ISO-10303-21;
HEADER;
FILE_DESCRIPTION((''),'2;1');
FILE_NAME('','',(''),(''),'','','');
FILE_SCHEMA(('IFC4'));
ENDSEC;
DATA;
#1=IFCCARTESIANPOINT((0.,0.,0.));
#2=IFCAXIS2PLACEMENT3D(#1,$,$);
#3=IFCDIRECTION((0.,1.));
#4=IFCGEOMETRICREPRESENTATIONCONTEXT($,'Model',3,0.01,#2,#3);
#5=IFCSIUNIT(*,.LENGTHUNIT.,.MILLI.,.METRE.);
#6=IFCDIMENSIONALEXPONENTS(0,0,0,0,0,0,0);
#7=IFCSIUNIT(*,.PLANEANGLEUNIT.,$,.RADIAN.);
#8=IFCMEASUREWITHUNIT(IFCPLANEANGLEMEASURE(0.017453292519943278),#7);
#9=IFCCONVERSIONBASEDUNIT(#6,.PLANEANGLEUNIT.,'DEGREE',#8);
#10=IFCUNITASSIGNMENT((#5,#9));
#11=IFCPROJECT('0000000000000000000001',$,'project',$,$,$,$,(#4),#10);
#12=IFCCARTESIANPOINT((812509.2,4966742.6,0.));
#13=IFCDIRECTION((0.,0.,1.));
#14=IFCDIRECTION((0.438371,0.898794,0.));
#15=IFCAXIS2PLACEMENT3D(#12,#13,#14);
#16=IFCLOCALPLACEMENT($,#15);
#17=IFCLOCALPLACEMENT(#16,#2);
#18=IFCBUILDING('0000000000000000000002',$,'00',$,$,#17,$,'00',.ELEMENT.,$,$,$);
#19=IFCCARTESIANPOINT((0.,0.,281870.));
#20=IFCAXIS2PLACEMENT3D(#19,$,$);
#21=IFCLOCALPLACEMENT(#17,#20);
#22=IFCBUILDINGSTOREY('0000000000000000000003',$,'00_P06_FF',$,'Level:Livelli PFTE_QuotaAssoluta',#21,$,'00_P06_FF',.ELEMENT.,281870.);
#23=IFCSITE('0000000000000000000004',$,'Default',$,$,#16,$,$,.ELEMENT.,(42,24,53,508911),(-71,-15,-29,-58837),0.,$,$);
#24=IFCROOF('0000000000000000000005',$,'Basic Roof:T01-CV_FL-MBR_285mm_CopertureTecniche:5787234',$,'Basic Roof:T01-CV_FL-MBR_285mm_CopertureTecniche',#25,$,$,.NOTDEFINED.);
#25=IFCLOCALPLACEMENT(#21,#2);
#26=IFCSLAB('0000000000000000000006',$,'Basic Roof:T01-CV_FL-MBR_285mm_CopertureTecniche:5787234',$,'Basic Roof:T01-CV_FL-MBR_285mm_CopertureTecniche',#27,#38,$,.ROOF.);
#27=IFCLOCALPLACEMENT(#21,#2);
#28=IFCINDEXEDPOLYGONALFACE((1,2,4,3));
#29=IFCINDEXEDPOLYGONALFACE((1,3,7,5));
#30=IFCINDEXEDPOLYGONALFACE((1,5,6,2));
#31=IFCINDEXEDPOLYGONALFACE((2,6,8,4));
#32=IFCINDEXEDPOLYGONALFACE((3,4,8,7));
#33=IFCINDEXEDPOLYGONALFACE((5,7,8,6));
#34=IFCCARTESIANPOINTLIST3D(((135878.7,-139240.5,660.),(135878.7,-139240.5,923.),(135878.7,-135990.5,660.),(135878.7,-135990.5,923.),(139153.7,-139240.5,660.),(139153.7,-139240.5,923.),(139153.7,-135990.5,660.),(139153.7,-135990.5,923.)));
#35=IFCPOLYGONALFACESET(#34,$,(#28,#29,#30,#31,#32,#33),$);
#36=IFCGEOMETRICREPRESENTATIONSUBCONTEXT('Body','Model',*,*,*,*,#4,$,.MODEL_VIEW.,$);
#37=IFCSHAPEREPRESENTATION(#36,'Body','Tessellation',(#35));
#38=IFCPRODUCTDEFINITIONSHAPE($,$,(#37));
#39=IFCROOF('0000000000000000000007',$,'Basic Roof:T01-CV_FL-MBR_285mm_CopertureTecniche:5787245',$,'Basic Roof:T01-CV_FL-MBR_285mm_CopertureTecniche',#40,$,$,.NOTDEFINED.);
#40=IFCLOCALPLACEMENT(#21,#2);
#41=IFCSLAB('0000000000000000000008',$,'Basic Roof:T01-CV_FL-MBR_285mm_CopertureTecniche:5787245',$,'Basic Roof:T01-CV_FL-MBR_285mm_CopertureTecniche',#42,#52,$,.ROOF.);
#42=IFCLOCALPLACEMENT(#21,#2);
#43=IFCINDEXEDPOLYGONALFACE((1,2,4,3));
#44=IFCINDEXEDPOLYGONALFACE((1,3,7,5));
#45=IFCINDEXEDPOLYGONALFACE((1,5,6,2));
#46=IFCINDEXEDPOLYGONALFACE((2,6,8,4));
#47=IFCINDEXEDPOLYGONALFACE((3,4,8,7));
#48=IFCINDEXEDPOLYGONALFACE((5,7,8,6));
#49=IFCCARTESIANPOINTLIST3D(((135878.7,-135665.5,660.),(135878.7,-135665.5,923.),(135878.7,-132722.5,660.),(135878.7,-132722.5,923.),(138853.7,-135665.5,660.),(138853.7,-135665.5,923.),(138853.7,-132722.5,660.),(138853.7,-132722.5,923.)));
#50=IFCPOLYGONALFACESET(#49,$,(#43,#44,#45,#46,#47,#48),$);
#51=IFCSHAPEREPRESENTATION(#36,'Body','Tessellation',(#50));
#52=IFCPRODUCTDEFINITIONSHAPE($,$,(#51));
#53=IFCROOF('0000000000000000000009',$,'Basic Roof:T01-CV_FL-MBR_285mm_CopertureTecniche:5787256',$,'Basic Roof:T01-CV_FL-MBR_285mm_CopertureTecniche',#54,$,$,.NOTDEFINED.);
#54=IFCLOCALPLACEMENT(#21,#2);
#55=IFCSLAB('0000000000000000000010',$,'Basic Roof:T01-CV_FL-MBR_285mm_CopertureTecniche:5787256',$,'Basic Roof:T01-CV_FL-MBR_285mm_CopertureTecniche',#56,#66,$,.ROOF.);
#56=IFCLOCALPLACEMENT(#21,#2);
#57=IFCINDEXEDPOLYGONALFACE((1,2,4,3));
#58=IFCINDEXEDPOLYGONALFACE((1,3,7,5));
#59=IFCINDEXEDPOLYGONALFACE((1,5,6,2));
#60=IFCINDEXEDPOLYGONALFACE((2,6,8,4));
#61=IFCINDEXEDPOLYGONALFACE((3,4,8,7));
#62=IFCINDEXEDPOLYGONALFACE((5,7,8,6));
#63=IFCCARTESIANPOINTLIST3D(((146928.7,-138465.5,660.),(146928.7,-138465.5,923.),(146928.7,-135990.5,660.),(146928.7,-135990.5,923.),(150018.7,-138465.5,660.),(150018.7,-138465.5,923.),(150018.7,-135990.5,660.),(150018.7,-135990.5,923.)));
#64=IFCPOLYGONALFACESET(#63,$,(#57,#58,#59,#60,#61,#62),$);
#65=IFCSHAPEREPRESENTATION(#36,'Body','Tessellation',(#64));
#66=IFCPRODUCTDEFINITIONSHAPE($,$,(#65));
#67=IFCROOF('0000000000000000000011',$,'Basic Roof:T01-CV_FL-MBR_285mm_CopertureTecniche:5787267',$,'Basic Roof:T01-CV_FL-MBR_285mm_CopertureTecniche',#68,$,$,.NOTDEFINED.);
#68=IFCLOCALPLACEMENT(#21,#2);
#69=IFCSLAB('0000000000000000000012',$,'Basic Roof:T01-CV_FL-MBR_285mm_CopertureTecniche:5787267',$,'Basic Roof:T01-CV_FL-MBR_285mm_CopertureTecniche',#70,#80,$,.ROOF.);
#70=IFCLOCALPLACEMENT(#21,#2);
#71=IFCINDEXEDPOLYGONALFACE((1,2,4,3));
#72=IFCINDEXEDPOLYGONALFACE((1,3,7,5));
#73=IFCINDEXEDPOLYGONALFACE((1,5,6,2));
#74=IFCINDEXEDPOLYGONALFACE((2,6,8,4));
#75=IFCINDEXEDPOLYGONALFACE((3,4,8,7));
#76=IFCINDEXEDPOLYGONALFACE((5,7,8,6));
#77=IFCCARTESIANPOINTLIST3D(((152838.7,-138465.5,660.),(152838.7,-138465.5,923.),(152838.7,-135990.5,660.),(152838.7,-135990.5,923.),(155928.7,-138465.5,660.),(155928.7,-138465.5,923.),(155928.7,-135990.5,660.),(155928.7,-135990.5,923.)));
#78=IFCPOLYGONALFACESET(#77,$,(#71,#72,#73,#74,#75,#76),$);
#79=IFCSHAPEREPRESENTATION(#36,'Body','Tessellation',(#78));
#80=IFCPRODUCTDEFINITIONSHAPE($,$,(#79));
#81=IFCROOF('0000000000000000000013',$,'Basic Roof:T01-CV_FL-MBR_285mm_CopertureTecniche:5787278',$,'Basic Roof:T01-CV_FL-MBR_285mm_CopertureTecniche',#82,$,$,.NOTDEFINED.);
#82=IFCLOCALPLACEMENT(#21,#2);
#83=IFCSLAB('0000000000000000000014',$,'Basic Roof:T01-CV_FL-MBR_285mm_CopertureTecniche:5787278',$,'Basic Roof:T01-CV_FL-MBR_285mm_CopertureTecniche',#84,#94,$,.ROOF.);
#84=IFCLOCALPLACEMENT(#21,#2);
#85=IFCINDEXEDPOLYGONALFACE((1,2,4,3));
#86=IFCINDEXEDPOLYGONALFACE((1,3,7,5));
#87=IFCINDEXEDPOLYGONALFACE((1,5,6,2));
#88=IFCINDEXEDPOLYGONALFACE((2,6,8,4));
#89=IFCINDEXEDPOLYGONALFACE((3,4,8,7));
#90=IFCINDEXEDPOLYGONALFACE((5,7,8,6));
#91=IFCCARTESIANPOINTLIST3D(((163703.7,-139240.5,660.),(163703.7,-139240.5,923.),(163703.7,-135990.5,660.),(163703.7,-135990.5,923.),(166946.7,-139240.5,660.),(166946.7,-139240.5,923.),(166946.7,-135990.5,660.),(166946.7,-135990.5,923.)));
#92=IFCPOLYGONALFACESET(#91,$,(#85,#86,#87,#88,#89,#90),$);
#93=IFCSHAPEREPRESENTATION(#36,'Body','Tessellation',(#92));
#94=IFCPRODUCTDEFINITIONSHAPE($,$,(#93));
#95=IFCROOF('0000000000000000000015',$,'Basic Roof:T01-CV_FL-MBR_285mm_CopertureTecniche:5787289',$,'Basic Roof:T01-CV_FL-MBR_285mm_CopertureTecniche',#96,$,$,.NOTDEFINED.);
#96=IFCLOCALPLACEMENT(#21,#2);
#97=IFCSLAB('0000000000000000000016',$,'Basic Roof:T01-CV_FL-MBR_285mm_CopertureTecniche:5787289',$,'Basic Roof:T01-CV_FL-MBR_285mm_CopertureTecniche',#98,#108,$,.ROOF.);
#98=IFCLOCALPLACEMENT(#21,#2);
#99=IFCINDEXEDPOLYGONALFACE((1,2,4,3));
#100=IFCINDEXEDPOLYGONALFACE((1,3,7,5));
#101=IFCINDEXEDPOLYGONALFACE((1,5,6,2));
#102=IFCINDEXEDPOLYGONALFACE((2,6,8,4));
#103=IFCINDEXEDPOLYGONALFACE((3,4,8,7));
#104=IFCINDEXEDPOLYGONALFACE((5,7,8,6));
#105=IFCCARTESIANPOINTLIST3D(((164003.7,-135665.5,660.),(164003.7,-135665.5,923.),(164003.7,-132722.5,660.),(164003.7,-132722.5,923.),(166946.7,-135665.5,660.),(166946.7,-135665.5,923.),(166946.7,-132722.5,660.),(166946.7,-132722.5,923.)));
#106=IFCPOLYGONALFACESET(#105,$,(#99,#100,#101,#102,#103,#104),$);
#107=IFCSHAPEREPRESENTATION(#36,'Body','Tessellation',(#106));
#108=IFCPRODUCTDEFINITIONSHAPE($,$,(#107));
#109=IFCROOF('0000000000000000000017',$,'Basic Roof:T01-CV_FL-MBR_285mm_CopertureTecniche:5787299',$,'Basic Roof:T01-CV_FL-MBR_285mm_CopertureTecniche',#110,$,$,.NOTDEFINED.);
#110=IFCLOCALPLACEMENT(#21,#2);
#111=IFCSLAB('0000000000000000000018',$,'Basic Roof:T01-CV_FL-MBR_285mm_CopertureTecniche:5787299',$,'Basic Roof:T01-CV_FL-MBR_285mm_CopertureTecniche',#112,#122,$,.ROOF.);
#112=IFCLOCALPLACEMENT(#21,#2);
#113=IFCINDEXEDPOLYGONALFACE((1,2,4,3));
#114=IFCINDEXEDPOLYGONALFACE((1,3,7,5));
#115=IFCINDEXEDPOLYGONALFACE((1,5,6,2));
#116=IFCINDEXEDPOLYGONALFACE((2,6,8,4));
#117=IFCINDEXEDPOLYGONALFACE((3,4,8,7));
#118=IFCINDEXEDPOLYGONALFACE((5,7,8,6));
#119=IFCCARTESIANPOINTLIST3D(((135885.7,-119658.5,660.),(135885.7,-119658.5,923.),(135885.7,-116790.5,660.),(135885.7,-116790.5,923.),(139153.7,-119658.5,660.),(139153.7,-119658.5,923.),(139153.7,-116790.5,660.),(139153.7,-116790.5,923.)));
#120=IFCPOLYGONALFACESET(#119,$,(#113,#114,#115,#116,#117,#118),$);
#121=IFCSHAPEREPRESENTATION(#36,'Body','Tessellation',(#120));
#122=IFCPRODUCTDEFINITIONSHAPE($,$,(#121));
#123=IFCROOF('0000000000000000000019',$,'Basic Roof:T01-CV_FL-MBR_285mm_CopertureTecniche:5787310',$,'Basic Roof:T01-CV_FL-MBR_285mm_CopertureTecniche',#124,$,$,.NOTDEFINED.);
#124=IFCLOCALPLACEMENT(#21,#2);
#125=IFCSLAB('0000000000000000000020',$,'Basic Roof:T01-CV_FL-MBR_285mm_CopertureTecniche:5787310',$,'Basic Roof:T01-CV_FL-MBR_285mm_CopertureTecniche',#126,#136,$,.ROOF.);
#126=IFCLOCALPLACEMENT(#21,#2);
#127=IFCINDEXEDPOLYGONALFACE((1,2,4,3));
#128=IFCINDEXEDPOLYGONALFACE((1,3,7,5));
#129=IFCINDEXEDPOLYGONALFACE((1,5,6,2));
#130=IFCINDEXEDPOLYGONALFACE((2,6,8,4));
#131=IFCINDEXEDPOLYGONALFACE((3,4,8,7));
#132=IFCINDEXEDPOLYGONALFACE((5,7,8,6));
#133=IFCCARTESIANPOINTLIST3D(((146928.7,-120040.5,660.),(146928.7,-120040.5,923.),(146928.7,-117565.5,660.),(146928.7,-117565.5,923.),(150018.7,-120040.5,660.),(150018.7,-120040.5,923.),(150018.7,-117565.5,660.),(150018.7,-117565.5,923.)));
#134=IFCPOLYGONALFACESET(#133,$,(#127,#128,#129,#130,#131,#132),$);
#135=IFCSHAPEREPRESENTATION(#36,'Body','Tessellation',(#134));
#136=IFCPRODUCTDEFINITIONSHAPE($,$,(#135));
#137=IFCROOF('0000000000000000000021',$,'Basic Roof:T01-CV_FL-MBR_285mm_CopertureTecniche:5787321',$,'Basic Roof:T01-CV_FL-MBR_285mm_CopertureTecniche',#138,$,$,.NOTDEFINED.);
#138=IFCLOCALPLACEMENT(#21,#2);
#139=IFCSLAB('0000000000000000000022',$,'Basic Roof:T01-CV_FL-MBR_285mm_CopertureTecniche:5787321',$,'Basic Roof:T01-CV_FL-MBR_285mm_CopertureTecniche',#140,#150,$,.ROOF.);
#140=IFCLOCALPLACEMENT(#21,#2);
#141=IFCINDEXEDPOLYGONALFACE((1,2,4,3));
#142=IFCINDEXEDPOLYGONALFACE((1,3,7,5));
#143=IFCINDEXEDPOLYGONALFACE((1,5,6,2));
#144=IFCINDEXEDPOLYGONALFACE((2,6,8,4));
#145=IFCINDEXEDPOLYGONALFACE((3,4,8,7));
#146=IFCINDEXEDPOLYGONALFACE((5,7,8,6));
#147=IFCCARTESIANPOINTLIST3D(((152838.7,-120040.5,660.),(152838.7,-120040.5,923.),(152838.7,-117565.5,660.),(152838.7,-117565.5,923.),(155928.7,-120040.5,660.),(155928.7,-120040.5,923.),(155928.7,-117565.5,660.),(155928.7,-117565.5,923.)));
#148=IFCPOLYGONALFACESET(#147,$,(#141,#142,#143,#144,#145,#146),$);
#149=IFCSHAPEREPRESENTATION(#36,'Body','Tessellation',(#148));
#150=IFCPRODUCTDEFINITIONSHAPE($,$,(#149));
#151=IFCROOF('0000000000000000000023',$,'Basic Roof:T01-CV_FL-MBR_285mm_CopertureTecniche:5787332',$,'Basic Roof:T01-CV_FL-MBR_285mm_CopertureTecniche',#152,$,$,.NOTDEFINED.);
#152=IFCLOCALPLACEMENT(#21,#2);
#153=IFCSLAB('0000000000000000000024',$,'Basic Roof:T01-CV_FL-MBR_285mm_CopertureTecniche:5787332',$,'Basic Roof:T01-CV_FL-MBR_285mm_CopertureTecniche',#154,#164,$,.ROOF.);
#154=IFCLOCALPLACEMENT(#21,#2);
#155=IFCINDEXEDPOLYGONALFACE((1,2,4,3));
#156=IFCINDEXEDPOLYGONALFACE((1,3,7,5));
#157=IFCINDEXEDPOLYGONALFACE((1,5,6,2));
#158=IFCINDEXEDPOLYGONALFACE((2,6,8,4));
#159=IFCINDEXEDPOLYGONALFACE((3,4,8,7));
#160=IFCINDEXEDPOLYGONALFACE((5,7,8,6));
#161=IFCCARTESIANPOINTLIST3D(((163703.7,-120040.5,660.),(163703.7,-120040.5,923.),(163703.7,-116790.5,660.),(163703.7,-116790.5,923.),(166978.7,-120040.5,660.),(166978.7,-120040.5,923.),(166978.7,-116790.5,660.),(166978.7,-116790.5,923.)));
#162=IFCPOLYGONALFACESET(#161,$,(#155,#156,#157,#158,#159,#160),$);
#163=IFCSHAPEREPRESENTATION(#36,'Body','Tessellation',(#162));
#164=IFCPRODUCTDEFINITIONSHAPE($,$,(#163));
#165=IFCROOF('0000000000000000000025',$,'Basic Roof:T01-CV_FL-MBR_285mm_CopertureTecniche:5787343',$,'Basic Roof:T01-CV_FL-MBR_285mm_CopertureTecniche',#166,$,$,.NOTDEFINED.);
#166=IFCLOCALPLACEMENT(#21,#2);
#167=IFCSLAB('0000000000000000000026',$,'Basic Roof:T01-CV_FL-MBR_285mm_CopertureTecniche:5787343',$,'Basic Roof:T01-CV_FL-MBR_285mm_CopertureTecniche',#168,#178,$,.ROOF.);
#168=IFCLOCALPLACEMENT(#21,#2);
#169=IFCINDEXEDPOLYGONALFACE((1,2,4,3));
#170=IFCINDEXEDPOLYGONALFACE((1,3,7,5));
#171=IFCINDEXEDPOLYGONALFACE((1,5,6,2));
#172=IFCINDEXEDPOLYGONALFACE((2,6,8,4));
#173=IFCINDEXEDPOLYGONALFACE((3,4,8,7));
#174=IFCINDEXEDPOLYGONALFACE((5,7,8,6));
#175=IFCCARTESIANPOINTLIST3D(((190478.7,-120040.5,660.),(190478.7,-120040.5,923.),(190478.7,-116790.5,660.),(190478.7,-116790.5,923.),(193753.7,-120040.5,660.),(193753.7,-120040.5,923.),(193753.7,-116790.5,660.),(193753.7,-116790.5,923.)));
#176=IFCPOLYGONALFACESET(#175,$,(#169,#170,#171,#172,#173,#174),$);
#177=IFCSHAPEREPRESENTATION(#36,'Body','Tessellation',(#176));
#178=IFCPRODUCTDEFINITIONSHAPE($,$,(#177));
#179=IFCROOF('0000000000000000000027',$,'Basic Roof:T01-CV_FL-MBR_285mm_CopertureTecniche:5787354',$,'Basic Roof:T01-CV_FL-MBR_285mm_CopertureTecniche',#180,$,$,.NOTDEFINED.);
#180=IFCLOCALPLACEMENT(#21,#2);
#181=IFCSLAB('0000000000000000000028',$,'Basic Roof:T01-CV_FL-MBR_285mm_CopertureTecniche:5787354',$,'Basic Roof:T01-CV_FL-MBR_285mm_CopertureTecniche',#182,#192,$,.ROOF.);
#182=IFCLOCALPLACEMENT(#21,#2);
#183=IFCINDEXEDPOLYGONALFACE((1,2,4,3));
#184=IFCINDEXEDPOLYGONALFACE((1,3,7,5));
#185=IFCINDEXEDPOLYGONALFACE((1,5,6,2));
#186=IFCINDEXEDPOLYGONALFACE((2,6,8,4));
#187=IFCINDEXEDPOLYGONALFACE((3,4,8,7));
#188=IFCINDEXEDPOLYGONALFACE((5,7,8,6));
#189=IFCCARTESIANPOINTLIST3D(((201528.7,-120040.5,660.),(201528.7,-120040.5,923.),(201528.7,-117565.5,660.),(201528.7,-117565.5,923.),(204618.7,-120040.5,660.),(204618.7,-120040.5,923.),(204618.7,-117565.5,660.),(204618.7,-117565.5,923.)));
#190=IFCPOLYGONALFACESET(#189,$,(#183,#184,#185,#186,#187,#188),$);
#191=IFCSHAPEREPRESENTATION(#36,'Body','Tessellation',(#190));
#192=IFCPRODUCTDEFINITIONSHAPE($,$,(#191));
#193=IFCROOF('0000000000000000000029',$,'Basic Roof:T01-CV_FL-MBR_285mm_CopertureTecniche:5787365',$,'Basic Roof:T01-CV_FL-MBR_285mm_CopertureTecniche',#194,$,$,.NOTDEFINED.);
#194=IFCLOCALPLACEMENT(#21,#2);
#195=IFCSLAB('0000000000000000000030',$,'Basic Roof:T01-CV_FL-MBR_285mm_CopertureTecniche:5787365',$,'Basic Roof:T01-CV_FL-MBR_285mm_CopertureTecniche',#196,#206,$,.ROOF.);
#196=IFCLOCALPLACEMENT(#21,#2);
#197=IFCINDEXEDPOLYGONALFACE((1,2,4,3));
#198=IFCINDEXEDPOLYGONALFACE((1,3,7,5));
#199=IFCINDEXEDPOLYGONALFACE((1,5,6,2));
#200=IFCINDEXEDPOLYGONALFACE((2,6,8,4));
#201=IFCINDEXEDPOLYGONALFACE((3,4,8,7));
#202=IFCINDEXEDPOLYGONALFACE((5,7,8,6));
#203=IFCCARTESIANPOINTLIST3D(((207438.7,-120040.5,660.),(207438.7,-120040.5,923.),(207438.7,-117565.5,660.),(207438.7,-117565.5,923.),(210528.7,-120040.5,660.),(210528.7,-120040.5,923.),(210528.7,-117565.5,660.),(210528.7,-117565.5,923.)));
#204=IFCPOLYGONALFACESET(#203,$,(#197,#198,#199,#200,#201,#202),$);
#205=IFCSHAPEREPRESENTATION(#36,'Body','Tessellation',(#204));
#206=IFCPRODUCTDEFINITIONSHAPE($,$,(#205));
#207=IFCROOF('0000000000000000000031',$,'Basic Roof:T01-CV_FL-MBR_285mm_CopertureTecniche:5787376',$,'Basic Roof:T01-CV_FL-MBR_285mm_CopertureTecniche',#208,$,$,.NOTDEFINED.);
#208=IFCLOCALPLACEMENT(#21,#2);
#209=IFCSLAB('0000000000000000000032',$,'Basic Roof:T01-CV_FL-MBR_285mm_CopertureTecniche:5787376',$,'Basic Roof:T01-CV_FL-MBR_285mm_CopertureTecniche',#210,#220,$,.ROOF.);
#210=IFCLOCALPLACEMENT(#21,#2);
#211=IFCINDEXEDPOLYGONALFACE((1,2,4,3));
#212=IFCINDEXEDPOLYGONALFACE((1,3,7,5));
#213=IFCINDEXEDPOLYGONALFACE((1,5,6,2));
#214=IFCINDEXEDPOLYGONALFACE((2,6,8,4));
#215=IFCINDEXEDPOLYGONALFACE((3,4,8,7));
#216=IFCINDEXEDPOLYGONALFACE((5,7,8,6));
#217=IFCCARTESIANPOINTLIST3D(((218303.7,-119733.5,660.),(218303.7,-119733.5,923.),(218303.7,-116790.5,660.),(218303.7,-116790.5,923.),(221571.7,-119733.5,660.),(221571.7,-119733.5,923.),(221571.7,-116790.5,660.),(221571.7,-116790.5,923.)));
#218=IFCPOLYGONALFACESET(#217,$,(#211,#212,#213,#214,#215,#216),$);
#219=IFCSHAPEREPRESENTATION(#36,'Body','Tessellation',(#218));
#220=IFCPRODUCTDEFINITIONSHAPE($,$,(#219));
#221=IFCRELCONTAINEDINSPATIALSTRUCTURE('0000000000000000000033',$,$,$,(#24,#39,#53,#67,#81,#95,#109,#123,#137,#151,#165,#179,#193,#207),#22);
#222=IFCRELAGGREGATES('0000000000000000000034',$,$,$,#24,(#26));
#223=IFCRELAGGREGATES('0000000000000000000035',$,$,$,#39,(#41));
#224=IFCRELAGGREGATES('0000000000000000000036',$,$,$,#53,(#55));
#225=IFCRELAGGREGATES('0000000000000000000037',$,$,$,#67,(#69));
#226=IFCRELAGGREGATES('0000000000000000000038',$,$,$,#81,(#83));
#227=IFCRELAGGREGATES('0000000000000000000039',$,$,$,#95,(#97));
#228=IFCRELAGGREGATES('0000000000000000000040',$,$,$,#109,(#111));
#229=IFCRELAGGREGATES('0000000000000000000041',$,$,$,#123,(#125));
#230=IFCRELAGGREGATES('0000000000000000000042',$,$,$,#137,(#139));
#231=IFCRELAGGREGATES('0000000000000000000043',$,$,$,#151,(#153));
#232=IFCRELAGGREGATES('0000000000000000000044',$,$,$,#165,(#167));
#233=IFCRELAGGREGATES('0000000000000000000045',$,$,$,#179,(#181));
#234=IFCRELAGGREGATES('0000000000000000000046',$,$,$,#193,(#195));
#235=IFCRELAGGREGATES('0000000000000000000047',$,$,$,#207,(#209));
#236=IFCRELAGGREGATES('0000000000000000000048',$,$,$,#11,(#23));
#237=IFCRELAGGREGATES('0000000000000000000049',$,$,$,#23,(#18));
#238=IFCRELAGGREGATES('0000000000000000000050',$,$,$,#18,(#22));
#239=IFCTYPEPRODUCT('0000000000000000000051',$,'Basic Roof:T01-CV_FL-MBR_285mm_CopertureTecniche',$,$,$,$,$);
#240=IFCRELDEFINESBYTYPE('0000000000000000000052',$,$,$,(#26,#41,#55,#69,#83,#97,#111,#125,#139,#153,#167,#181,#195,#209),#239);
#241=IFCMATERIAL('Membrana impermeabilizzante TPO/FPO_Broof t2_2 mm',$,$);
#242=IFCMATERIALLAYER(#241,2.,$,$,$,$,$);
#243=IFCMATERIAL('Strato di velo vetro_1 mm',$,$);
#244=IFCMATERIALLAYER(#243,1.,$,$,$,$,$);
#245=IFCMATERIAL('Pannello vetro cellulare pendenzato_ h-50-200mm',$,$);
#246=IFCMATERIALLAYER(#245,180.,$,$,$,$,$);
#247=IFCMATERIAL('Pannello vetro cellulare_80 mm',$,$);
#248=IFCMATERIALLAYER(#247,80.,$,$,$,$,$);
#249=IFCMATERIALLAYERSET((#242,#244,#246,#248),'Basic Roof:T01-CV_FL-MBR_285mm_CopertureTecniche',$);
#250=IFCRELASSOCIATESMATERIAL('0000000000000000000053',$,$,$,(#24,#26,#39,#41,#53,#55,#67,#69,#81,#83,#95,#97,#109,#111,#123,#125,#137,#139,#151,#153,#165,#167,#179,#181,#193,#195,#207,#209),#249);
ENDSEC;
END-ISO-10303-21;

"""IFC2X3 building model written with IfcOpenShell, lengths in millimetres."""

from ifc_helpers import new_model, entity, si_unit, converted_unit, direction, frame, frame_2d, origin, place, context, subcontext, project, spatial, rectangle, extrude, material, layer, layer_set, type_object, element, aggregate, save


model = new_model("IFC2X3")

# Units and contexts
model_context = context("Model", 3, precision=0.01, world=origin(), true_north=direction((0.0, 1.0)))
body_context = subcontext(model_context, "Body", "Model", "MODEL_VIEW")
ifc_project = project(units=[si_unit("LENGTHUNIT", "METRE", prefix="MILLI"), converted_unit("PLANEANGLEUNIT", "DEGREE", entity("IfcPlaneAngleMeasure", 0.017453292519943278), si_unit("PLANEANGLEUNIT", "RADIAN"), dimensions=[0, 0, 0, 0, 0, 0, 0])], contexts=[model_context])

# Site, building, storey
site_placement = place(None, frame((812509.2, 4966742.6, 0.0), z_axis=(0.0, 0.0, 1.0), x_axis=(0.438371, 0.898794, 0.0)))
site = spatial("IfcSite", under=ifc_project, at=site_placement, Name="Default", CompositionType="ELEMENT", RefLatitude=(42, 24, 53, 508911), RefLongitude=(-71, -15, -29, -58837), RefElevation=0.0)
building_placement = place(site_placement, origin())
building = spatial("IfcBuilding", under=site, at=building_placement, Name="00", LongName="00", CompositionType="ELEMENT")
storey_placement = place(building_placement, frame((0.0, 0.0, 281870.0)))
storey = spatial("IfcBuildingStorey", under=building, at=storey_placement, Name="00_P06_FF", ObjectType="Level:Livelli PFTE_QuotaAssoluta", LongName="00_P06_FF", CompositionType="ELEMENT", Elevation=281870.0)

# Roofs, slabs
ifc_material_1 = material(Name="Membrana impermeabilizzante TPO/FPO_Broof t2_2 mm")
ifc_layer_1 = layer(ifc_material_1, 2.0)
ifc_material_2 = material(Name="Strato di velo vetro_1 mm")
ifc_layer_2 = layer(ifc_material_2, 1.0)
ifc_material_3 = material(Name="Pannello vetro cellulare pendenzato_ h-50-200mm")
ifc_layer_3 = layer(ifc_material_3, 180.0)
ifc_material_4 = material(Name="Pannello vetro cellulare_80 mm")
ifc_layer_4 = layer(ifc_material_4, 80.0)
ifc_layer_set = layer_set([ifc_layer_1, ifc_layer_2, ifc_layer_3, ifc_layer_4], Name="Basic Roof:T01-CV_FL-MBR_285mm_CopertureTecniche")
roof_1_placement = place(storey_placement, frame((135878.7, -139240.5, 660.0)))
roof_1 = element("IfcRoof", 1, at=roof_1_placement, inside=storey, material=ifc_layer_set, Name="Basic Roof:T01-CV_FL-MBR_285mm_CopertureTecniche:5787234", ObjectType="Basic Roof:T01-CV_FL-MBR_285mm_CopertureTecniche", ShapeType="NOTDEFINED")
type_product = type_object("IfcTypeProduct", Name="Basic Roof:T01-CV_FL-MBR_285mm_CopertureTecniche")
slab_1_placement = place(roof_1_placement, origin())
slab_1 = element("IfcSlab", 2, at=slab_1_placement, type_object=type_product, material=ifc_layer_set, Name="Basic Roof:T01-CV_FL-MBR_285mm_CopertureTecniche:5787234", ObjectType="Basic Roof:T01-CV_FL-MBR_285mm_CopertureTecniche", PredefinedType="ROOF", context=body_context, shape_type="SweptSolid", body=[
    extrude(rectangle(XDim=3250.0, YDim=3275.0, at=frame_2d((0.0, 0.0), x_axis=(0.0, -1.0))), frame((1637.5, 1625.0, 0.0)), (0.0, 0.0, 1.0), 263.0),
])
aggregate(roof_1, [slab_1])
roof_2_placement = place(storey_placement, frame((135878.7, -135665.5, 660.0)))
roof_2 = element("IfcRoof", 3, at=roof_2_placement, inside=storey, material=ifc_layer_set, Name="Basic Roof:T01-CV_FL-MBR_285mm_CopertureTecniche:5787245", ObjectType="Basic Roof:T01-CV_FL-MBR_285mm_CopertureTecniche", ShapeType="NOTDEFINED")
slab_2_placement = place(roof_2_placement, origin())
slab_2 = element("IfcSlab", 4, at=slab_2_placement, type_object=type_product, material=ifc_layer_set, Name="Basic Roof:T01-CV_FL-MBR_285mm_CopertureTecniche:5787245", ObjectType="Basic Roof:T01-CV_FL-MBR_285mm_CopertureTecniche", PredefinedType="ROOF", context=body_context, shape_type="SweptSolid", body=[
    extrude(rectangle(XDim=2975.0, YDim=2943.0, at=frame_2d((0.0, 0.0), x_axis=(-1.0, 0.0))), frame((1487.5, 1471.5, 0.0)), (0.0, 0.0, 1.0), 263.0),
])
aggregate(roof_2, [slab_2])
roof_3_placement = place(storey_placement, frame((146928.7, -138465.5, 660.0)))
roof_3 = element("IfcRoof", 5, at=roof_3_placement, inside=storey, material=ifc_layer_set, Name="Basic Roof:T01-CV_FL-MBR_285mm_CopertureTecniche:5787256", ObjectType="Basic Roof:T01-CV_FL-MBR_285mm_CopertureTecniche", ShapeType="NOTDEFINED")
slab_3_placement = place(roof_3_placement, origin())
slab_3 = element("IfcSlab", 6, at=slab_3_placement, type_object=type_product, material=ifc_layer_set, Name="Basic Roof:T01-CV_FL-MBR_285mm_CopertureTecniche:5787256", ObjectType="Basic Roof:T01-CV_FL-MBR_285mm_CopertureTecniche", PredefinedType="ROOF", context=body_context, shape_type="SweptSolid", body=[
    extrude(rectangle(XDim=3090.0, YDim=2475.0, at=frame_2d((0.0, 0.0), x_axis=(1.0, 0.0))), frame((1545.0, 1237.5, 0.0)), (0.0, 0.0, 1.0), 263.0),
])
aggregate(roof_3, [slab_3])
roof_4_placement = place(storey_placement, frame((152838.7, -138465.5, 660.0)))
roof_4 = element("IfcRoof", 7, at=roof_4_placement, inside=storey, material=ifc_layer_set, Name="Basic Roof:T01-CV_FL-MBR_285mm_CopertureTecniche:5787267", ObjectType="Basic Roof:T01-CV_FL-MBR_285mm_CopertureTecniche", ShapeType="NOTDEFINED")
slab_4_placement = place(roof_4_placement, origin())
slab_4 = element("IfcSlab", 8, at=slab_4_placement, type_object=type_product, material=ifc_layer_set, Name="Basic Roof:T01-CV_FL-MBR_285mm_CopertureTecniche:5787267", ObjectType="Basic Roof:T01-CV_FL-MBR_285mm_CopertureTecniche", PredefinedType="ROOF", context=body_context, shape_type="SweptSolid", body=[
    extrude(rectangle(XDim=3090.0, YDim=2475.0, at=frame_2d((0.0, 0.0), x_axis=(1.0, 0.0))), frame((1545.0, 1237.5, 0.0)), (0.0, 0.0, 1.0), 263.0),
])
aggregate(roof_4, [slab_4])
roof_5_placement = place(storey_placement, frame((163703.7, -139240.5, 660.0)))
roof_5 = element("IfcRoof", 9, at=roof_5_placement, inside=storey, material=ifc_layer_set, Name="Basic Roof:T01-CV_FL-MBR_285mm_CopertureTecniche:5787278", ObjectType="Basic Roof:T01-CV_FL-MBR_285mm_CopertureTecniche", ShapeType="NOTDEFINED")
slab_5_placement = place(roof_5_placement, origin())
slab_5 = element("IfcSlab", 10, at=slab_5_placement, type_object=type_product, material=ifc_layer_set, Name="Basic Roof:T01-CV_FL-MBR_285mm_CopertureTecniche:5787278", ObjectType="Basic Roof:T01-CV_FL-MBR_285mm_CopertureTecniche", PredefinedType="ROOF", context=body_context, shape_type="SweptSolid", body=[
    extrude(rectangle(XDim=3250.0, YDim=3243.0, at=frame_2d((0.0, 0.0), x_axis=(0.0, 1.0))), frame((1621.5, 1625.0, 0.0)), (0.0, 0.0, 1.0), 263.0),
])
aggregate(roof_5, [slab_5])
roof_6_placement = place(storey_placement, frame((164003.7, -135665.5, 660.0)))
roof_6 = element("IfcRoof", 11, at=roof_6_placement, inside=storey, material=ifc_layer_set, Name="Basic Roof:T01-CV_FL-MBR_285mm_CopertureTecniche:5787289", ObjectType="Basic Roof:T01-CV_FL-MBR_285mm_CopertureTecniche", ShapeType="NOTDEFINED")
slab_6_placement = place(roof_6_placement, origin())
slab_6 = element("IfcSlab", 12, at=slab_6_placement, type_object=type_product, material=ifc_layer_set, Name="Basic Roof:T01-CV_FL-MBR_285mm_CopertureTecniche:5787289", ObjectType="Basic Roof:T01-CV_FL-MBR_285mm_CopertureTecniche", PredefinedType="ROOF", context=body_context, shape_type="SweptSolid", body=[
    extrude(rectangle(XDim=2943.0, YDim=2943.0, at=frame_2d((0.0, 0.0), x_axis=(-1.0, 0.0))), frame((1471.5, 1471.5, 0.0)), (0.0, 0.0, 1.0), 263.0),
])
aggregate(roof_6, [slab_6])
roof_7_placement = place(storey_placement, frame((135885.7, -119658.5, 660.0)))
roof_7 = element("IfcRoof", 13, at=roof_7_placement, inside=storey, material=ifc_layer_set, Name="Basic Roof:T01-CV_FL-MBR_285mm_CopertureTecniche:5787299", ObjectType="Basic Roof:T01-CV_FL-MBR_285mm_CopertureTecniche", ShapeType="NOTDEFINED")
slab_7_placement = place(roof_7_placement, origin())
slab_7 = element("IfcSlab", 14, at=slab_7_placement, type_object=type_product, material=ifc_layer_set, Name="Basic Roof:T01-CV_FL-MBR_285mm_CopertureTecniche:5787299", ObjectType="Basic Roof:T01-CV_FL-MBR_285mm_CopertureTecniche", PredefinedType="ROOF", context=body_context, shape_type="SweptSolid", body=[
    extrude(rectangle(XDim=3268.0, YDim=2868.0, at=frame_2d((0.0, 0.0), x_axis=(1.0, 0.0))), frame((1634.0, 1434.0, 0.0)), (0.0, 0.0, 1.0), 263.0),
])
aggregate(roof_7, [slab_7])
roof_8_placement = place(storey_placement, frame((146928.7, -120040.5, 660.0)))
roof_8 = element("IfcRoof", 15, at=roof_8_placement, inside=storey, material=ifc_layer_set, Name="Basic Roof:T01-CV_FL-MBR_285mm_CopertureTecniche:5787310", ObjectType="Basic Roof:T01-CV_FL-MBR_285mm_CopertureTecniche", ShapeType="NOTDEFINED")
slab_8_placement = place(roof_8_placement, origin())
slab_8 = element("IfcSlab", 16, at=slab_8_placement, type_object=type_product, material=ifc_layer_set, Name="Basic Roof:T01-CV_FL-MBR_285mm_CopertureTecniche:5787310", ObjectType="Basic Roof:T01-CV_FL-MBR_285mm_CopertureTecniche", PredefinedType="ROOF", context=body_context, shape_type="SweptSolid", body=[
    extrude(rectangle(XDim=3090.0, YDim=2475.0, at=frame_2d((0.0, 0.0), x_axis=(1.0, 0.0))), frame((1545.0, 1237.5, 0.0)), (0.0, 0.0, 1.0), 263.0),
])
aggregate(roof_8, [slab_8])
roof_9_placement = place(storey_placement, frame((152838.7, -120040.5, 660.0)))
roof_9 = element("IfcRoof", 17, at=roof_9_placement, inside=storey, material=ifc_layer_set, Name="Basic Roof:T01-CV_FL-MBR_285mm_CopertureTecniche:5787321", ObjectType="Basic Roof:T01-CV_FL-MBR_285mm_CopertureTecniche", ShapeType="NOTDEFINED")
slab_9_placement = place(roof_9_placement, origin())
slab_9 = element("IfcSlab", 18, at=slab_9_placement, type_object=type_product, material=ifc_layer_set, Name="Basic Roof:T01-CV_FL-MBR_285mm_CopertureTecniche:5787321", ObjectType="Basic Roof:T01-CV_FL-MBR_285mm_CopertureTecniche", PredefinedType="ROOF", context=body_context, shape_type="SweptSolid", body=[
    extrude(rectangle(XDim=2475.0, YDim=3090.0, at=frame_2d((0.0, 0.0), x_axis=(0.0, 1.0))), frame((1545.0, 1237.5, 0.0)), (0.0, 0.0, 1.0), 263.0),
])
aggregate(roof_9, [slab_9])
roof_10_placement = place(storey_placement, frame((163703.7, -120040.5, 660.0)))
roof_10 = element("IfcRoof", 19, at=roof_10_placement, inside=storey, material=ifc_layer_set, Name="Basic Roof:T01-CV_FL-MBR_285mm_CopertureTecniche:5787332", ObjectType="Basic Roof:T01-CV_FL-MBR_285mm_CopertureTecniche", ShapeType="NOTDEFINED")
slab_10_placement = place(roof_10_placement, origin())
slab_10 = element("IfcSlab", 20, at=slab_10_placement, type_object=type_product, material=ifc_layer_set, Name="Basic Roof:T01-CV_FL-MBR_285mm_CopertureTecniche:5787332", ObjectType="Basic Roof:T01-CV_FL-MBR_285mm_CopertureTecniche", PredefinedType="ROOF", context=body_context, shape_type="SweptSolid", body=[
    extrude(rectangle(XDim=3250.0, YDim=3275.0, at=frame_2d((0.0, 0.0), x_axis=(0.0, 1.0))), frame((1637.5, 1625.0, 0.0)), (0.0, 0.0, 1.0), 263.0),
])
aggregate(roof_10, [slab_10])
roof_11_placement = place(storey_placement, frame((190478.7, -120040.5, 660.0)))
roof_11 = element("IfcRoof", 21, at=roof_11_placement, inside=storey, material=ifc_layer_set, Name="Basic Roof:T01-CV_FL-MBR_285mm_CopertureTecniche:5787343", ObjectType="Basic Roof:T01-CV_FL-MBR_285mm_CopertureTecniche", ShapeType="NOTDEFINED")
slab_11_placement = place(roof_11_placement, origin())
slab_11 = element("IfcSlab", 22, at=slab_11_placement, type_object=type_product, material=ifc_layer_set, Name="Basic Roof:T01-CV_FL-MBR_285mm_CopertureTecniche:5787343", ObjectType="Basic Roof:T01-CV_FL-MBR_285mm_CopertureTecniche", PredefinedType="ROOF", context=body_context, shape_type="SweptSolid", body=[
    extrude(rectangle(XDim=3275.0, YDim=3250.0, at=frame_2d((0.0, 0.0), x_axis=(-1.0, 0.0))), frame((1637.5, 1625.0, 0.0)), (0.0, 0.0, 1.0), 263.0),
])
aggregate(roof_11, [slab_11])
roof_12_placement = place(storey_placement, frame((201528.7, -120040.5, 660.0)))
roof_12 = element("IfcRoof", 23, at=roof_12_placement, inside=storey, material=ifc_layer_set, Name="Basic Roof:T01-CV_FL-MBR_285mm_CopertureTecniche:5787354", ObjectType="Basic Roof:T01-CV_FL-MBR_285mm_CopertureTecniche", ShapeType="NOTDEFINED")
slab_12_placement = place(roof_12_placement, origin())
slab_12 = element("IfcSlab", 24, at=slab_12_placement, type_object=type_product, material=ifc_layer_set, Name="Basic Roof:T01-CV_FL-MBR_285mm_CopertureTecniche:5787354", ObjectType="Basic Roof:T01-CV_FL-MBR_285mm_CopertureTecniche", PredefinedType="ROOF", context=body_context, shape_type="SweptSolid", body=[
    extrude(rectangle(XDim=3090.0, YDim=2475.0, at=frame_2d((0.0, 0.0), x_axis=(-1.0, 0.0))), frame((1545.0, 1237.5, 0.0)), (0.0, 0.0, 1.0), 263.0),
])
aggregate(roof_12, [slab_12])
roof_13_placement = place(storey_placement, frame((207438.7, -120040.5, 660.0)))
roof_13 = element("IfcRoof", 25, at=roof_13_placement, inside=storey, material=ifc_layer_set, Name="Basic Roof:T01-CV_FL-MBR_285mm_CopertureTecniche:5787365", ObjectType="Basic Roof:T01-CV_FL-MBR_285mm_CopertureTecniche", ShapeType="NOTDEFINED")
slab_13_placement = place(roof_13_placement, origin())
slab_13 = element("IfcSlab", 26, at=slab_13_placement, type_object=type_product, material=ifc_layer_set, Name="Basic Roof:T01-CV_FL-MBR_285mm_CopertureTecniche:5787365", ObjectType="Basic Roof:T01-CV_FL-MBR_285mm_CopertureTecniche", PredefinedType="ROOF", context=body_context, shape_type="SweptSolid", body=[
    extrude(rectangle(XDim=3090.0, YDim=2475.0, at=frame_2d((0.0, 0.0), x_axis=(1.0, 0.0))), frame((1545.0, 1237.5, 0.0)), (0.0, 0.0, 1.0), 263.0),
])
aggregate(roof_13, [slab_13])
roof_14_placement = place(storey_placement, frame((218303.7, -119733.5, 660.0)))
roof_14 = element("IfcRoof", 27, at=roof_14_placement, inside=storey, material=ifc_layer_set, Name="Basic Roof:T01-CV_FL-MBR_285mm_CopertureTecniche:5787376", ObjectType="Basic Roof:T01-CV_FL-MBR_285mm_CopertureTecniche", ShapeType="NOTDEFINED")
slab_14_placement = place(roof_14_placement, origin())
slab_14 = element("IfcSlab", 28, at=slab_14_placement, type_object=type_product, material=ifc_layer_set, Name="Basic Roof:T01-CV_FL-MBR_285mm_CopertureTecniche:5787376", ObjectType="Basic Roof:T01-CV_FL-MBR_285mm_CopertureTecniche", PredefinedType="ROOF", context=body_context, shape_type="SweptSolid", body=[
    extrude(rectangle(XDim=2943.0, YDim=3268.0, at=frame_2d((0.0, 0.0), x_axis=(0.0, 1.0))), frame((1634.0, 1471.5, 0.0)), (0.0, 0.0, 1.0), 263.0),
])
aggregate(roof_14, [slab_14])

save(model, "model.ifc")
